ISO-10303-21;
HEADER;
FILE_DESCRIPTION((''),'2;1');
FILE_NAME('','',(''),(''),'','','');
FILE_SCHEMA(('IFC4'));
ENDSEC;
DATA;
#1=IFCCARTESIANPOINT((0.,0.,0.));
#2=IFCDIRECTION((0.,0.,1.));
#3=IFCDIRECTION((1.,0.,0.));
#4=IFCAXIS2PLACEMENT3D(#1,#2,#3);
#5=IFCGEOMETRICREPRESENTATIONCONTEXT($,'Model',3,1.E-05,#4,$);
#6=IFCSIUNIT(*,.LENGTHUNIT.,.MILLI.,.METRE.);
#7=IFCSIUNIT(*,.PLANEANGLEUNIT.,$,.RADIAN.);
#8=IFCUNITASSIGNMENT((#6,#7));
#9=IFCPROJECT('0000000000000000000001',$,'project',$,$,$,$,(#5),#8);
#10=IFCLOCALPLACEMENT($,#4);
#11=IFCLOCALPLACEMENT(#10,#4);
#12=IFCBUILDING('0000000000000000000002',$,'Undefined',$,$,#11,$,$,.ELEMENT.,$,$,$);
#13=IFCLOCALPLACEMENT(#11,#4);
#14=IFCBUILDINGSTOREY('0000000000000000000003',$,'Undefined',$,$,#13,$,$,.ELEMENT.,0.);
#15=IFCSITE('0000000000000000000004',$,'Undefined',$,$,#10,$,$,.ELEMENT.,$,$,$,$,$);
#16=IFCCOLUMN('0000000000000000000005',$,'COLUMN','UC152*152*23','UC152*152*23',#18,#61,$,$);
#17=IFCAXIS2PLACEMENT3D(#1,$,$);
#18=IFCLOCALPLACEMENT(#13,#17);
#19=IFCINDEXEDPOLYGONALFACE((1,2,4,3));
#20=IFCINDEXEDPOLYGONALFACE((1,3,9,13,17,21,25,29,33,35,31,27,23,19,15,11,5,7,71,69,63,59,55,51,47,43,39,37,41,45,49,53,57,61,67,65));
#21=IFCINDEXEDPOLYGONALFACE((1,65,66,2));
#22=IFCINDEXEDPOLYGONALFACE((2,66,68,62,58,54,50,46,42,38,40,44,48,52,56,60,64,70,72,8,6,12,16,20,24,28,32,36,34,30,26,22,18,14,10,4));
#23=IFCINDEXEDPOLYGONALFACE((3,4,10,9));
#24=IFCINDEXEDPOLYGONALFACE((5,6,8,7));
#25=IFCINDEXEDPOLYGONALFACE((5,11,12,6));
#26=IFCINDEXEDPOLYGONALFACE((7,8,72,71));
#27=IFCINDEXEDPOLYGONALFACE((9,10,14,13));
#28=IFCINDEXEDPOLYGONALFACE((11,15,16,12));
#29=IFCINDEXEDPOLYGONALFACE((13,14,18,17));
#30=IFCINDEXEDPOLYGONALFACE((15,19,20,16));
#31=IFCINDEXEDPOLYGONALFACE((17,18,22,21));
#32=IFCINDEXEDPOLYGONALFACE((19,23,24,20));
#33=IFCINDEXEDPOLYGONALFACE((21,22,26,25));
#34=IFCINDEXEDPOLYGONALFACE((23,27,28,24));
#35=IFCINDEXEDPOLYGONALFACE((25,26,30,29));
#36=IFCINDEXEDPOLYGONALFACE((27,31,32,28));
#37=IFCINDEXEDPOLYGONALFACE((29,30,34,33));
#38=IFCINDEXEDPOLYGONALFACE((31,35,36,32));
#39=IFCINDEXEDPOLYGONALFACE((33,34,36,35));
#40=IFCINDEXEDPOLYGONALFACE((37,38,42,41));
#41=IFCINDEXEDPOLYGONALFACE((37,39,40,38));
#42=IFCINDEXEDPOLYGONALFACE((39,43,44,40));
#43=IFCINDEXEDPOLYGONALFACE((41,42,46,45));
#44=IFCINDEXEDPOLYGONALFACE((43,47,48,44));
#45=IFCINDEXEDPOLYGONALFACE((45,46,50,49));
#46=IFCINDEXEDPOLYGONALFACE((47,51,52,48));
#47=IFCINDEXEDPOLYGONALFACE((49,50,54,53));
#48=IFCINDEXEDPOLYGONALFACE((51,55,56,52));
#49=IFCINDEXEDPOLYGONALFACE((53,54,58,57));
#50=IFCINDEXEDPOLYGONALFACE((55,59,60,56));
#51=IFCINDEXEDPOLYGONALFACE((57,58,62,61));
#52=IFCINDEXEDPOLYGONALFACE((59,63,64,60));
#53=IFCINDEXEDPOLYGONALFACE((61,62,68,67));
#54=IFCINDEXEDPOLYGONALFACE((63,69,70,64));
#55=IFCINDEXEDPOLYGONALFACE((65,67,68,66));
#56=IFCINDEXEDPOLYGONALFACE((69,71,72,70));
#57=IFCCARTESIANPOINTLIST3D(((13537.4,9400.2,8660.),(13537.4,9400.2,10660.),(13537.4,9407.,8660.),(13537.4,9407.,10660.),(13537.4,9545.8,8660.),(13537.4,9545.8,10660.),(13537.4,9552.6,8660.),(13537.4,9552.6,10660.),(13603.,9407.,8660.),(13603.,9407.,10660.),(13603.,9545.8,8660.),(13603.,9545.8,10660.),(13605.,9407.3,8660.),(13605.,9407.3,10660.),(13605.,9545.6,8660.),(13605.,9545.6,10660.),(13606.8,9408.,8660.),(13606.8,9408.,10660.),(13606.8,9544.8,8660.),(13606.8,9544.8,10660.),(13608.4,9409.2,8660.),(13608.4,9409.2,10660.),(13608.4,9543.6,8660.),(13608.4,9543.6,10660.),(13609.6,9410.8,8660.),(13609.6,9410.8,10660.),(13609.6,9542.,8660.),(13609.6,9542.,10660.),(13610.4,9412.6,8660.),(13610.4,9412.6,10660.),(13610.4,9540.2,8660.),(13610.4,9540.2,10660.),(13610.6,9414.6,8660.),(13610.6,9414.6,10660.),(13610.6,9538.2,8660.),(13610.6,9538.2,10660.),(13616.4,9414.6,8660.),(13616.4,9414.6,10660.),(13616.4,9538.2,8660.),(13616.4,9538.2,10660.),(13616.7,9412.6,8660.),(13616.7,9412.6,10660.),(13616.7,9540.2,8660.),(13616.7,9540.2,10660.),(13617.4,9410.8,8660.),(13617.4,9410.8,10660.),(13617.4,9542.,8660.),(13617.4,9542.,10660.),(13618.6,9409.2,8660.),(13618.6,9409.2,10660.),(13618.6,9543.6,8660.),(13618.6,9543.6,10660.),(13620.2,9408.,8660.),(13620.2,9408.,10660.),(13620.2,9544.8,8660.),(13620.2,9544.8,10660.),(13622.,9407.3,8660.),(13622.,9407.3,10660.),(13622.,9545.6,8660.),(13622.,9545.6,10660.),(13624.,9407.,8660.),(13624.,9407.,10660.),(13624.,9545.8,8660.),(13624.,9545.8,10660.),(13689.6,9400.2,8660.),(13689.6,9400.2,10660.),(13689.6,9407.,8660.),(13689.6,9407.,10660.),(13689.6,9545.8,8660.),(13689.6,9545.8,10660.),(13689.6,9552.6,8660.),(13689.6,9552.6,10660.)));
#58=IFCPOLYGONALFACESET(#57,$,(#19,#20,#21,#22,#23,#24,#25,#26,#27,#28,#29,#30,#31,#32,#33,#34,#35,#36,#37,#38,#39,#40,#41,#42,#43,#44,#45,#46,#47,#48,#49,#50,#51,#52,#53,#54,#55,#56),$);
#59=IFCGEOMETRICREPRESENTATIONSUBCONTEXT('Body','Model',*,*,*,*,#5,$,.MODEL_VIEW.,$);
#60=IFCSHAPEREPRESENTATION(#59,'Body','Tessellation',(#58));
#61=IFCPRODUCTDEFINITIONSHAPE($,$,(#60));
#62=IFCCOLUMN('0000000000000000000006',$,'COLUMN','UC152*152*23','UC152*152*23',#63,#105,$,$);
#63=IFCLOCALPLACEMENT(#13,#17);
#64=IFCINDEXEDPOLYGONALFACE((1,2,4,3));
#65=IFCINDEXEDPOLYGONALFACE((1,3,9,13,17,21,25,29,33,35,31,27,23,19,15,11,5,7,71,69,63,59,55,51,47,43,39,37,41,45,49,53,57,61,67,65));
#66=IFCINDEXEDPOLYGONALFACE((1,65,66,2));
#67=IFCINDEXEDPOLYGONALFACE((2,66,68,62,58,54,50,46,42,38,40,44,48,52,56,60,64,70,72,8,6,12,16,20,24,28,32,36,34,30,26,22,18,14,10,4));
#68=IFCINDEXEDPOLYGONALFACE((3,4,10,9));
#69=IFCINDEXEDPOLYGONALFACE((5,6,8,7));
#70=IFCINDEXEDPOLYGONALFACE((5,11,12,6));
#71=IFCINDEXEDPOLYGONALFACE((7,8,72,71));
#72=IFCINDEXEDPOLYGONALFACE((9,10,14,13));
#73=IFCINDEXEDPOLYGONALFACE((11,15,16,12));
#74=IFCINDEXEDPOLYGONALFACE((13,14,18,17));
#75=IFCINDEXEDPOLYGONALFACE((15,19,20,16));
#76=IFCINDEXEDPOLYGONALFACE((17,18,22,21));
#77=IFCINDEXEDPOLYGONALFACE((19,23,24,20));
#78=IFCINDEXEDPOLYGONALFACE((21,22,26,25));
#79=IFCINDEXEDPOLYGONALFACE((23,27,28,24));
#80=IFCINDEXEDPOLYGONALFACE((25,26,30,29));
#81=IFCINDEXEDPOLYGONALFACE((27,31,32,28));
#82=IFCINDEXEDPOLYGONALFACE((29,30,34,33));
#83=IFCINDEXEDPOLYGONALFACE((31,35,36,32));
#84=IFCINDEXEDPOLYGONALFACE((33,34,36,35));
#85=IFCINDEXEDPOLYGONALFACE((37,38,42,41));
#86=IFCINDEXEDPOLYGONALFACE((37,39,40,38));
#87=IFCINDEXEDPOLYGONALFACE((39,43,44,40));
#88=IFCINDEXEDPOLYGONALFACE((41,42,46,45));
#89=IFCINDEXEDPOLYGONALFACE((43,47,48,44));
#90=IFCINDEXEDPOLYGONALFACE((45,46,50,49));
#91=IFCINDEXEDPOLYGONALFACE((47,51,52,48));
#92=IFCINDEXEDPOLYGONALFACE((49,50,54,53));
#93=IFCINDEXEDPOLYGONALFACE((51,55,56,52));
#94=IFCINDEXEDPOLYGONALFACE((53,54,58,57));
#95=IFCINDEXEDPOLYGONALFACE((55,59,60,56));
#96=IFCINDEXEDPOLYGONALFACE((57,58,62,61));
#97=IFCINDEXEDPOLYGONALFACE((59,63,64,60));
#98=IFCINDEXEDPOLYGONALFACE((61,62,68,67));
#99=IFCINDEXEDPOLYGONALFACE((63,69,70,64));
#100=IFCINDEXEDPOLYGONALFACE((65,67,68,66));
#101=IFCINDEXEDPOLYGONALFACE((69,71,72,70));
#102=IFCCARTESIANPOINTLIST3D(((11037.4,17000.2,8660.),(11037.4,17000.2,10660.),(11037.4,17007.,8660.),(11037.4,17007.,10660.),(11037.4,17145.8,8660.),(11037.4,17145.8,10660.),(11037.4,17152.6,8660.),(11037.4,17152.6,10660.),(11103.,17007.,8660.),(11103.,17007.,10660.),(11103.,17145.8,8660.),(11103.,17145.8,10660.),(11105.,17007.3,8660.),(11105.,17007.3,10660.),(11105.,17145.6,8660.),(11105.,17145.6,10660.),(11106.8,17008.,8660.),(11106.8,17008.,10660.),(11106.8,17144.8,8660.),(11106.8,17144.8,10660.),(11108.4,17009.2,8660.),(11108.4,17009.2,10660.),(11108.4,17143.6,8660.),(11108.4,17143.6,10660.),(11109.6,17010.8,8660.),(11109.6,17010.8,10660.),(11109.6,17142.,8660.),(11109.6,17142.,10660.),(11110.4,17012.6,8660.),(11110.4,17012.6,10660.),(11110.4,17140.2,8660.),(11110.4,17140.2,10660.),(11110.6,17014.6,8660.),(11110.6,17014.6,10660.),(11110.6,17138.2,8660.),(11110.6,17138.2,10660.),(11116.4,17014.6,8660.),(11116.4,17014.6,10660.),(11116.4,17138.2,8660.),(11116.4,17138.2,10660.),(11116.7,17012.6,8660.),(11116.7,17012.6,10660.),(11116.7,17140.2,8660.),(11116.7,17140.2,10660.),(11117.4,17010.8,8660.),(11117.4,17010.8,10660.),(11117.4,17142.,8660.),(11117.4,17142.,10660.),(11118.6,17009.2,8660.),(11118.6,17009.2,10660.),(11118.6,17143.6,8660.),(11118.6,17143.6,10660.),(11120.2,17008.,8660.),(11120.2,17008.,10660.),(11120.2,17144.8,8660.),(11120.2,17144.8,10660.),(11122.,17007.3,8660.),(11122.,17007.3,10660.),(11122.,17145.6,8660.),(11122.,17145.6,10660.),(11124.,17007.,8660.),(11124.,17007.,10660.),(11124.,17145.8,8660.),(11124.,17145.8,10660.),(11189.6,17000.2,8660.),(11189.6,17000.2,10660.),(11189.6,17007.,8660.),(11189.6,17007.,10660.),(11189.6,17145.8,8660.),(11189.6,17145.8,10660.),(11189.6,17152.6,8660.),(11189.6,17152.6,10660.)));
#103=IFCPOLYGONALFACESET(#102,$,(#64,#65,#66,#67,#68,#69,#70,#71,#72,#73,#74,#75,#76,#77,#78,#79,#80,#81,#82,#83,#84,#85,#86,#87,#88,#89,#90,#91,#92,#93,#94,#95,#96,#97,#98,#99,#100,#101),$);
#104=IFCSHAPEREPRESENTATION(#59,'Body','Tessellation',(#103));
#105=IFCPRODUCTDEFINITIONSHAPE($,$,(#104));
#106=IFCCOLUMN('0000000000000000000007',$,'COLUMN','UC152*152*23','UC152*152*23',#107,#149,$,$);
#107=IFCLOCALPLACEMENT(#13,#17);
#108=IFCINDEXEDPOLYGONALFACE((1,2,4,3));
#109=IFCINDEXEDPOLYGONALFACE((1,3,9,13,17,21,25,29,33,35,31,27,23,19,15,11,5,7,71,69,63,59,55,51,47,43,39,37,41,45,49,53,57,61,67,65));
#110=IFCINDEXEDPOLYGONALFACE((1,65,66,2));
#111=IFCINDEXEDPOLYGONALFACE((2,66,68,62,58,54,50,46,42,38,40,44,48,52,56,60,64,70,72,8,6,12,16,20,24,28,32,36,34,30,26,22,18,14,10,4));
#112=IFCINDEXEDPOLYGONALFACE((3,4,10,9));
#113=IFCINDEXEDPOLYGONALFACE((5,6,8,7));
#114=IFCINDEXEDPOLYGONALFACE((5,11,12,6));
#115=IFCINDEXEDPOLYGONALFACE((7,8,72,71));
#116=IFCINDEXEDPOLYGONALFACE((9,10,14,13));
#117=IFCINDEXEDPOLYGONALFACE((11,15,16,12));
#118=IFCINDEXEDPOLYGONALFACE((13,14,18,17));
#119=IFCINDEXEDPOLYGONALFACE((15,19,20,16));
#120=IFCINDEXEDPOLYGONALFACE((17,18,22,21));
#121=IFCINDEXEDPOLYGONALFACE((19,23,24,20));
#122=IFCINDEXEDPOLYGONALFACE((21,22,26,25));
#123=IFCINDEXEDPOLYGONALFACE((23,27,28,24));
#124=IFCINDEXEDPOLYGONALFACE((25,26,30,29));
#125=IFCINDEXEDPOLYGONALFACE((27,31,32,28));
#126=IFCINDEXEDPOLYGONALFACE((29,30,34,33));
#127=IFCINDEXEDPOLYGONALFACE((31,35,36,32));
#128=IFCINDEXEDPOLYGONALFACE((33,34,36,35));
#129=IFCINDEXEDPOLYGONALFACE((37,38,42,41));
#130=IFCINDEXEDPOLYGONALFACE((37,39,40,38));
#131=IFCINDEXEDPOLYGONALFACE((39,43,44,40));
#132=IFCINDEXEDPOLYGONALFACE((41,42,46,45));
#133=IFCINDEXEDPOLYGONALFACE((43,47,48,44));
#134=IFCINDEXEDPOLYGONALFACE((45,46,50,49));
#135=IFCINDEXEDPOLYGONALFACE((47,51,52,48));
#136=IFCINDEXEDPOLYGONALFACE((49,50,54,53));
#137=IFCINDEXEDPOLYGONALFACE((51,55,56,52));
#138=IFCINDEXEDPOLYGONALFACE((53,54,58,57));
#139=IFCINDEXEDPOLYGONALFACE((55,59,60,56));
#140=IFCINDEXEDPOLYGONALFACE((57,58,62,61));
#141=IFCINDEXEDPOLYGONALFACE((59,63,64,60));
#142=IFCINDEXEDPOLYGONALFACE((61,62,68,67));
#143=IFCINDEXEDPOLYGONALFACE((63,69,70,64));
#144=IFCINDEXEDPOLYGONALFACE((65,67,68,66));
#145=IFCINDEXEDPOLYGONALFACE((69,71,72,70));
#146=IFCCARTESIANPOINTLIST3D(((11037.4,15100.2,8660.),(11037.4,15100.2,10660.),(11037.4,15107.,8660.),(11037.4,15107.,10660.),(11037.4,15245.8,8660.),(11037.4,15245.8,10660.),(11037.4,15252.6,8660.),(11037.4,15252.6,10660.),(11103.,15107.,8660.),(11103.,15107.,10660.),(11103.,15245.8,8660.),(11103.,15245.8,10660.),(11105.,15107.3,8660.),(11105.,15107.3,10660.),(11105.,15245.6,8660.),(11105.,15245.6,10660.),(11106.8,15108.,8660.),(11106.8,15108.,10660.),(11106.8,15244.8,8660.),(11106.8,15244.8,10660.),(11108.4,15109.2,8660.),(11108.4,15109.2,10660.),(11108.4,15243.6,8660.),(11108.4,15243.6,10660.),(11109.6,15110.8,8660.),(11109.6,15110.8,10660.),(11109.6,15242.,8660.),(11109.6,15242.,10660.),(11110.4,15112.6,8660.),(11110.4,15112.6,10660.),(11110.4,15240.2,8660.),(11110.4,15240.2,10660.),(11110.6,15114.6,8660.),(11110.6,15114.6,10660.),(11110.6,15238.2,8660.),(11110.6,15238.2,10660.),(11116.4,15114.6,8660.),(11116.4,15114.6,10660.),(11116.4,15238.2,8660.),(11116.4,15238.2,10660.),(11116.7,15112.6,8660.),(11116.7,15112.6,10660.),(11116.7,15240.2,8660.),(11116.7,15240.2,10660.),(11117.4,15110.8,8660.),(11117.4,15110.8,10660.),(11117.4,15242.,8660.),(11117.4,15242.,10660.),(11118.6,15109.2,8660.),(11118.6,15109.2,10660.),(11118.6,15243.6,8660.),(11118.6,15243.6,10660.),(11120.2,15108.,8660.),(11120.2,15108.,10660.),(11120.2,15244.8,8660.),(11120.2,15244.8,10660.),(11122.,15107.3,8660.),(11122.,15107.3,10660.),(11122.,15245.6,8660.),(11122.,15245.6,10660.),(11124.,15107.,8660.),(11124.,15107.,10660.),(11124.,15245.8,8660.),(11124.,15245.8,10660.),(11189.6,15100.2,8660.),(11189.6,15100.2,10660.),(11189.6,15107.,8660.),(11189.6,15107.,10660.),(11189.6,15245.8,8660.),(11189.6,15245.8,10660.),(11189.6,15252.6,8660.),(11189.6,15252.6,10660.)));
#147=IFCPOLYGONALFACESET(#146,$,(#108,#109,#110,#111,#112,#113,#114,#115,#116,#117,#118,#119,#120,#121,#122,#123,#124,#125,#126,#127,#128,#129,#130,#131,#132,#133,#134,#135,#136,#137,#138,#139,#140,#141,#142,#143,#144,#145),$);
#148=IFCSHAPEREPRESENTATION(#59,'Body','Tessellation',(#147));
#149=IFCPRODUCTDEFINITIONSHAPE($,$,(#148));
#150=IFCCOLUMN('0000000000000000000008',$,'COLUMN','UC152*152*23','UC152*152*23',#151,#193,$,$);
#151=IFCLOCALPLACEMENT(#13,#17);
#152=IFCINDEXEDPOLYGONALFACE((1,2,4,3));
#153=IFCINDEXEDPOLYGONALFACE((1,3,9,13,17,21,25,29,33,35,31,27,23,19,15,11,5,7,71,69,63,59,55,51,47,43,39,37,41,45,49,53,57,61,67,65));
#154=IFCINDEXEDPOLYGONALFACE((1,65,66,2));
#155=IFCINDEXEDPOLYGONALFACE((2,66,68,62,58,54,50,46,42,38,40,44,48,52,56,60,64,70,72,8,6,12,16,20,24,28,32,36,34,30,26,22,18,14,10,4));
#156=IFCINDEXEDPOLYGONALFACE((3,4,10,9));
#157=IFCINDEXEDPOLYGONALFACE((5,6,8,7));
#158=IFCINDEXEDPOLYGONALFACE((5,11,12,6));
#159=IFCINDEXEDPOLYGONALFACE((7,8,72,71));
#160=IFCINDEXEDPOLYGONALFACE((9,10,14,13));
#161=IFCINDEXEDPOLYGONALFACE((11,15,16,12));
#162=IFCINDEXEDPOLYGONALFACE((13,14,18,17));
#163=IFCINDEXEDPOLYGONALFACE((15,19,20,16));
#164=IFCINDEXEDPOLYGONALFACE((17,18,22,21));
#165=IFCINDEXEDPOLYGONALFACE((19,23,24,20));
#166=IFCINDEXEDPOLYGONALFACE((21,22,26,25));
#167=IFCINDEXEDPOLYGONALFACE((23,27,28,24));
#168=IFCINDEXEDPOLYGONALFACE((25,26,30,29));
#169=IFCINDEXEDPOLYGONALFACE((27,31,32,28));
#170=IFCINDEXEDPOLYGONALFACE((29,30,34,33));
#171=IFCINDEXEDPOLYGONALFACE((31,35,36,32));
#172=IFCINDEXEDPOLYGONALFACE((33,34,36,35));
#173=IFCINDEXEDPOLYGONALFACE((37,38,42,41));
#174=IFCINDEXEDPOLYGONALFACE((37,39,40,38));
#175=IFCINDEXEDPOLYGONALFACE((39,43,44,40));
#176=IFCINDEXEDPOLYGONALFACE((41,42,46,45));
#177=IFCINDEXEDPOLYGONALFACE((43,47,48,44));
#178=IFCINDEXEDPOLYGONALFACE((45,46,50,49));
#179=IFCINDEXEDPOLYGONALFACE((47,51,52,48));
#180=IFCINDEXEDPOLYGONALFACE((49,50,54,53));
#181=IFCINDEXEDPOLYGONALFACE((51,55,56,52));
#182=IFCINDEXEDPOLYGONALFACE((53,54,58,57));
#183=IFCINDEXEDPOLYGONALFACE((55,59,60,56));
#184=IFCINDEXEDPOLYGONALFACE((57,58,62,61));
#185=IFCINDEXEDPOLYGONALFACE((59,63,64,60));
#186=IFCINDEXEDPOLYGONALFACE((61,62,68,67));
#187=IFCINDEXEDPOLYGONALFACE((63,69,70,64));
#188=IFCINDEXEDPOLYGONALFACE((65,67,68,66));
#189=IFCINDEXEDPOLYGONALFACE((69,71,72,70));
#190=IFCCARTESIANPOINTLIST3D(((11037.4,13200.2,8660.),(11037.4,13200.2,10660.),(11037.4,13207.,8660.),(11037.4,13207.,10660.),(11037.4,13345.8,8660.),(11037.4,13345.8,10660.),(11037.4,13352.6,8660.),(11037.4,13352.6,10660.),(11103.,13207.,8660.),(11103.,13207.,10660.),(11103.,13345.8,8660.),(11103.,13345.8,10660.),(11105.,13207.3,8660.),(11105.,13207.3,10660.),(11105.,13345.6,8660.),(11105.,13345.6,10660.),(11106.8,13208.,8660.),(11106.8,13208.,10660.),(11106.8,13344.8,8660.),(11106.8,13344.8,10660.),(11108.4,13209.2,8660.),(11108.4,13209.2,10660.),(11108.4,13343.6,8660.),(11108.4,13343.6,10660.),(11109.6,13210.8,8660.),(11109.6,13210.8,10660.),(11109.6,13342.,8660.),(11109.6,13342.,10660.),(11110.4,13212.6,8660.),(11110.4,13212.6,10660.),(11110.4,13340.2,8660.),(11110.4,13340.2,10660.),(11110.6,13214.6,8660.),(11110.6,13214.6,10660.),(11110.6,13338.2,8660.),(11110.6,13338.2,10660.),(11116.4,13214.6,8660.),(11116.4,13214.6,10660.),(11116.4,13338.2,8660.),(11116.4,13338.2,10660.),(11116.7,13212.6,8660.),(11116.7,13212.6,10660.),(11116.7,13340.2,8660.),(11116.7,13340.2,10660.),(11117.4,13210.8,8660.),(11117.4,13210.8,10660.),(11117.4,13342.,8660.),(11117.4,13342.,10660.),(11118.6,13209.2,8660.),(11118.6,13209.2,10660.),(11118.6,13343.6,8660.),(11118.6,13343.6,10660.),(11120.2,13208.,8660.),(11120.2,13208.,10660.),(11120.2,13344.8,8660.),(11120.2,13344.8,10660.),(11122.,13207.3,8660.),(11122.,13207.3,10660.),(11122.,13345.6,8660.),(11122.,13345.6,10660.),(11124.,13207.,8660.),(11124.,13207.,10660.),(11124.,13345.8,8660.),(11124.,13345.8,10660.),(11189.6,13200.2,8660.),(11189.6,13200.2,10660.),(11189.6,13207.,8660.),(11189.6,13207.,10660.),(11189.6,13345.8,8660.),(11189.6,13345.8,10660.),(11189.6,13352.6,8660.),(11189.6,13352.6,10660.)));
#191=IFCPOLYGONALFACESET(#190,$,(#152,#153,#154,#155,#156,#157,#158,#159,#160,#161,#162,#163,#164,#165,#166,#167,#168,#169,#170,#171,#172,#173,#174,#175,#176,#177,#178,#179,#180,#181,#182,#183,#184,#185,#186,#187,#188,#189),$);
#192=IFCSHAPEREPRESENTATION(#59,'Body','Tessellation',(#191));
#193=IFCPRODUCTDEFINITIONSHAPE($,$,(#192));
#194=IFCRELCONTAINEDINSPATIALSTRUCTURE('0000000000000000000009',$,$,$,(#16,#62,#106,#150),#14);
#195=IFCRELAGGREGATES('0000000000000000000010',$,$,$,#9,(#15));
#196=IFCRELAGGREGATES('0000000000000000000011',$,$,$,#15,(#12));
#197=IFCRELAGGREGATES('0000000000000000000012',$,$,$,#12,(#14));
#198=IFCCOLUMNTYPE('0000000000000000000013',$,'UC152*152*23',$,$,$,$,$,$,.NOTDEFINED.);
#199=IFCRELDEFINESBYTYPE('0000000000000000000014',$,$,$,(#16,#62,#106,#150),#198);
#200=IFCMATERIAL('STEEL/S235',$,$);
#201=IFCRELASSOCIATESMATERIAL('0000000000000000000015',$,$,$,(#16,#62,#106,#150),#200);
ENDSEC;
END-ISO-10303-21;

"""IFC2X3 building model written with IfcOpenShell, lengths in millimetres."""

from ifc_helpers import new_model, si_unit, frame, origin_with_axes, origin_2d_with_axis, place, context, subcontext, project, spatial, i_section, extrude, material, type_object, element, save


model = new_model("IFC2X3")

# Units and contexts
model_context = context("Model", 3, precision=1e-05, world=origin_with_axes())
body_context = subcontext(model_context, "Body", "Model", "MODEL_VIEW")
ifc_project = project(units=[si_unit("LENGTHUNIT", "METRE", prefix="MILLI"), si_unit("PLANEANGLEUNIT", "RADIAN")], contexts=[model_context])

# Site, building, storey
site_placement = place(None, origin_with_axes())
site = spatial("IfcSite", under=ifc_project, at=site_placement, Name="Undefined", CompositionType="ELEMENT")
building_placement = place(site_placement, origin_with_axes())
building = spatial("IfcBuilding", under=site, at=building_placement, Name="Undefined", CompositionType="ELEMENT")
storey_placement = place(building_placement, origin_with_axes())
storey = spatial("IfcBuildingStorey", under=building, at=storey_placement, Name="Undefined", CompositionType="ELEMENT", Elevation=0.0)

# Columns
ifc_material = material(Name="STEEL/S235")
column_type = type_object("IfcColumnType", Name="UC152*152*23", PredefinedType="NOTDEFINED")
for number, where, z_axis, x_axis, name in (
    (1, (13613.5, 9476.4, 8660.0), (0.0, 0.0, 1.0), (0.0, -1.0, 0.0), "COLUMN"),
    (2, (11113.5, 17076.4, 8660.0), (0.0, 0.0, 1.0), (0.0, -1.0, 0.0), "COLUMN"),
    (3, (11113.5, 15176.4, 8660.0), (0.0, 0.0, 1.0), (0.0, -1.0, 0.0), "COLUMN"),
    (4, (11113.5, 13276.4, 8660.0), (0.0, 0.0, 1.0), (0.0, -1.0, 0.0), "COLUMN"),
):
    element("IfcColumn", number, at=place(storey_placement, frame(where, z_axis=z_axis, x_axis=x_axis)), inside=storey, type_object=column_type, material=ifc_material, Name=name, Description="UC152*152*23", ObjectType="UC152*152*23", context=body_context, shape_type="SweptSolid", body=[
        extrude(i_section(OverallWidth=152.2, OverallDepth=152.4, WebThickness=5.8, FlangeThickness=6.8, FilletRadius=7.6, at=origin_2d_with_axis()), frame((0.0, 0.0, 2000.0), z_axis=(0.0, 0.0, -1.0), x_axis=(0.0, 1.0, 0.0)), (0.0, 0.0, 1.0), 2000.0),
    ])

save(model, "model.ifc")
